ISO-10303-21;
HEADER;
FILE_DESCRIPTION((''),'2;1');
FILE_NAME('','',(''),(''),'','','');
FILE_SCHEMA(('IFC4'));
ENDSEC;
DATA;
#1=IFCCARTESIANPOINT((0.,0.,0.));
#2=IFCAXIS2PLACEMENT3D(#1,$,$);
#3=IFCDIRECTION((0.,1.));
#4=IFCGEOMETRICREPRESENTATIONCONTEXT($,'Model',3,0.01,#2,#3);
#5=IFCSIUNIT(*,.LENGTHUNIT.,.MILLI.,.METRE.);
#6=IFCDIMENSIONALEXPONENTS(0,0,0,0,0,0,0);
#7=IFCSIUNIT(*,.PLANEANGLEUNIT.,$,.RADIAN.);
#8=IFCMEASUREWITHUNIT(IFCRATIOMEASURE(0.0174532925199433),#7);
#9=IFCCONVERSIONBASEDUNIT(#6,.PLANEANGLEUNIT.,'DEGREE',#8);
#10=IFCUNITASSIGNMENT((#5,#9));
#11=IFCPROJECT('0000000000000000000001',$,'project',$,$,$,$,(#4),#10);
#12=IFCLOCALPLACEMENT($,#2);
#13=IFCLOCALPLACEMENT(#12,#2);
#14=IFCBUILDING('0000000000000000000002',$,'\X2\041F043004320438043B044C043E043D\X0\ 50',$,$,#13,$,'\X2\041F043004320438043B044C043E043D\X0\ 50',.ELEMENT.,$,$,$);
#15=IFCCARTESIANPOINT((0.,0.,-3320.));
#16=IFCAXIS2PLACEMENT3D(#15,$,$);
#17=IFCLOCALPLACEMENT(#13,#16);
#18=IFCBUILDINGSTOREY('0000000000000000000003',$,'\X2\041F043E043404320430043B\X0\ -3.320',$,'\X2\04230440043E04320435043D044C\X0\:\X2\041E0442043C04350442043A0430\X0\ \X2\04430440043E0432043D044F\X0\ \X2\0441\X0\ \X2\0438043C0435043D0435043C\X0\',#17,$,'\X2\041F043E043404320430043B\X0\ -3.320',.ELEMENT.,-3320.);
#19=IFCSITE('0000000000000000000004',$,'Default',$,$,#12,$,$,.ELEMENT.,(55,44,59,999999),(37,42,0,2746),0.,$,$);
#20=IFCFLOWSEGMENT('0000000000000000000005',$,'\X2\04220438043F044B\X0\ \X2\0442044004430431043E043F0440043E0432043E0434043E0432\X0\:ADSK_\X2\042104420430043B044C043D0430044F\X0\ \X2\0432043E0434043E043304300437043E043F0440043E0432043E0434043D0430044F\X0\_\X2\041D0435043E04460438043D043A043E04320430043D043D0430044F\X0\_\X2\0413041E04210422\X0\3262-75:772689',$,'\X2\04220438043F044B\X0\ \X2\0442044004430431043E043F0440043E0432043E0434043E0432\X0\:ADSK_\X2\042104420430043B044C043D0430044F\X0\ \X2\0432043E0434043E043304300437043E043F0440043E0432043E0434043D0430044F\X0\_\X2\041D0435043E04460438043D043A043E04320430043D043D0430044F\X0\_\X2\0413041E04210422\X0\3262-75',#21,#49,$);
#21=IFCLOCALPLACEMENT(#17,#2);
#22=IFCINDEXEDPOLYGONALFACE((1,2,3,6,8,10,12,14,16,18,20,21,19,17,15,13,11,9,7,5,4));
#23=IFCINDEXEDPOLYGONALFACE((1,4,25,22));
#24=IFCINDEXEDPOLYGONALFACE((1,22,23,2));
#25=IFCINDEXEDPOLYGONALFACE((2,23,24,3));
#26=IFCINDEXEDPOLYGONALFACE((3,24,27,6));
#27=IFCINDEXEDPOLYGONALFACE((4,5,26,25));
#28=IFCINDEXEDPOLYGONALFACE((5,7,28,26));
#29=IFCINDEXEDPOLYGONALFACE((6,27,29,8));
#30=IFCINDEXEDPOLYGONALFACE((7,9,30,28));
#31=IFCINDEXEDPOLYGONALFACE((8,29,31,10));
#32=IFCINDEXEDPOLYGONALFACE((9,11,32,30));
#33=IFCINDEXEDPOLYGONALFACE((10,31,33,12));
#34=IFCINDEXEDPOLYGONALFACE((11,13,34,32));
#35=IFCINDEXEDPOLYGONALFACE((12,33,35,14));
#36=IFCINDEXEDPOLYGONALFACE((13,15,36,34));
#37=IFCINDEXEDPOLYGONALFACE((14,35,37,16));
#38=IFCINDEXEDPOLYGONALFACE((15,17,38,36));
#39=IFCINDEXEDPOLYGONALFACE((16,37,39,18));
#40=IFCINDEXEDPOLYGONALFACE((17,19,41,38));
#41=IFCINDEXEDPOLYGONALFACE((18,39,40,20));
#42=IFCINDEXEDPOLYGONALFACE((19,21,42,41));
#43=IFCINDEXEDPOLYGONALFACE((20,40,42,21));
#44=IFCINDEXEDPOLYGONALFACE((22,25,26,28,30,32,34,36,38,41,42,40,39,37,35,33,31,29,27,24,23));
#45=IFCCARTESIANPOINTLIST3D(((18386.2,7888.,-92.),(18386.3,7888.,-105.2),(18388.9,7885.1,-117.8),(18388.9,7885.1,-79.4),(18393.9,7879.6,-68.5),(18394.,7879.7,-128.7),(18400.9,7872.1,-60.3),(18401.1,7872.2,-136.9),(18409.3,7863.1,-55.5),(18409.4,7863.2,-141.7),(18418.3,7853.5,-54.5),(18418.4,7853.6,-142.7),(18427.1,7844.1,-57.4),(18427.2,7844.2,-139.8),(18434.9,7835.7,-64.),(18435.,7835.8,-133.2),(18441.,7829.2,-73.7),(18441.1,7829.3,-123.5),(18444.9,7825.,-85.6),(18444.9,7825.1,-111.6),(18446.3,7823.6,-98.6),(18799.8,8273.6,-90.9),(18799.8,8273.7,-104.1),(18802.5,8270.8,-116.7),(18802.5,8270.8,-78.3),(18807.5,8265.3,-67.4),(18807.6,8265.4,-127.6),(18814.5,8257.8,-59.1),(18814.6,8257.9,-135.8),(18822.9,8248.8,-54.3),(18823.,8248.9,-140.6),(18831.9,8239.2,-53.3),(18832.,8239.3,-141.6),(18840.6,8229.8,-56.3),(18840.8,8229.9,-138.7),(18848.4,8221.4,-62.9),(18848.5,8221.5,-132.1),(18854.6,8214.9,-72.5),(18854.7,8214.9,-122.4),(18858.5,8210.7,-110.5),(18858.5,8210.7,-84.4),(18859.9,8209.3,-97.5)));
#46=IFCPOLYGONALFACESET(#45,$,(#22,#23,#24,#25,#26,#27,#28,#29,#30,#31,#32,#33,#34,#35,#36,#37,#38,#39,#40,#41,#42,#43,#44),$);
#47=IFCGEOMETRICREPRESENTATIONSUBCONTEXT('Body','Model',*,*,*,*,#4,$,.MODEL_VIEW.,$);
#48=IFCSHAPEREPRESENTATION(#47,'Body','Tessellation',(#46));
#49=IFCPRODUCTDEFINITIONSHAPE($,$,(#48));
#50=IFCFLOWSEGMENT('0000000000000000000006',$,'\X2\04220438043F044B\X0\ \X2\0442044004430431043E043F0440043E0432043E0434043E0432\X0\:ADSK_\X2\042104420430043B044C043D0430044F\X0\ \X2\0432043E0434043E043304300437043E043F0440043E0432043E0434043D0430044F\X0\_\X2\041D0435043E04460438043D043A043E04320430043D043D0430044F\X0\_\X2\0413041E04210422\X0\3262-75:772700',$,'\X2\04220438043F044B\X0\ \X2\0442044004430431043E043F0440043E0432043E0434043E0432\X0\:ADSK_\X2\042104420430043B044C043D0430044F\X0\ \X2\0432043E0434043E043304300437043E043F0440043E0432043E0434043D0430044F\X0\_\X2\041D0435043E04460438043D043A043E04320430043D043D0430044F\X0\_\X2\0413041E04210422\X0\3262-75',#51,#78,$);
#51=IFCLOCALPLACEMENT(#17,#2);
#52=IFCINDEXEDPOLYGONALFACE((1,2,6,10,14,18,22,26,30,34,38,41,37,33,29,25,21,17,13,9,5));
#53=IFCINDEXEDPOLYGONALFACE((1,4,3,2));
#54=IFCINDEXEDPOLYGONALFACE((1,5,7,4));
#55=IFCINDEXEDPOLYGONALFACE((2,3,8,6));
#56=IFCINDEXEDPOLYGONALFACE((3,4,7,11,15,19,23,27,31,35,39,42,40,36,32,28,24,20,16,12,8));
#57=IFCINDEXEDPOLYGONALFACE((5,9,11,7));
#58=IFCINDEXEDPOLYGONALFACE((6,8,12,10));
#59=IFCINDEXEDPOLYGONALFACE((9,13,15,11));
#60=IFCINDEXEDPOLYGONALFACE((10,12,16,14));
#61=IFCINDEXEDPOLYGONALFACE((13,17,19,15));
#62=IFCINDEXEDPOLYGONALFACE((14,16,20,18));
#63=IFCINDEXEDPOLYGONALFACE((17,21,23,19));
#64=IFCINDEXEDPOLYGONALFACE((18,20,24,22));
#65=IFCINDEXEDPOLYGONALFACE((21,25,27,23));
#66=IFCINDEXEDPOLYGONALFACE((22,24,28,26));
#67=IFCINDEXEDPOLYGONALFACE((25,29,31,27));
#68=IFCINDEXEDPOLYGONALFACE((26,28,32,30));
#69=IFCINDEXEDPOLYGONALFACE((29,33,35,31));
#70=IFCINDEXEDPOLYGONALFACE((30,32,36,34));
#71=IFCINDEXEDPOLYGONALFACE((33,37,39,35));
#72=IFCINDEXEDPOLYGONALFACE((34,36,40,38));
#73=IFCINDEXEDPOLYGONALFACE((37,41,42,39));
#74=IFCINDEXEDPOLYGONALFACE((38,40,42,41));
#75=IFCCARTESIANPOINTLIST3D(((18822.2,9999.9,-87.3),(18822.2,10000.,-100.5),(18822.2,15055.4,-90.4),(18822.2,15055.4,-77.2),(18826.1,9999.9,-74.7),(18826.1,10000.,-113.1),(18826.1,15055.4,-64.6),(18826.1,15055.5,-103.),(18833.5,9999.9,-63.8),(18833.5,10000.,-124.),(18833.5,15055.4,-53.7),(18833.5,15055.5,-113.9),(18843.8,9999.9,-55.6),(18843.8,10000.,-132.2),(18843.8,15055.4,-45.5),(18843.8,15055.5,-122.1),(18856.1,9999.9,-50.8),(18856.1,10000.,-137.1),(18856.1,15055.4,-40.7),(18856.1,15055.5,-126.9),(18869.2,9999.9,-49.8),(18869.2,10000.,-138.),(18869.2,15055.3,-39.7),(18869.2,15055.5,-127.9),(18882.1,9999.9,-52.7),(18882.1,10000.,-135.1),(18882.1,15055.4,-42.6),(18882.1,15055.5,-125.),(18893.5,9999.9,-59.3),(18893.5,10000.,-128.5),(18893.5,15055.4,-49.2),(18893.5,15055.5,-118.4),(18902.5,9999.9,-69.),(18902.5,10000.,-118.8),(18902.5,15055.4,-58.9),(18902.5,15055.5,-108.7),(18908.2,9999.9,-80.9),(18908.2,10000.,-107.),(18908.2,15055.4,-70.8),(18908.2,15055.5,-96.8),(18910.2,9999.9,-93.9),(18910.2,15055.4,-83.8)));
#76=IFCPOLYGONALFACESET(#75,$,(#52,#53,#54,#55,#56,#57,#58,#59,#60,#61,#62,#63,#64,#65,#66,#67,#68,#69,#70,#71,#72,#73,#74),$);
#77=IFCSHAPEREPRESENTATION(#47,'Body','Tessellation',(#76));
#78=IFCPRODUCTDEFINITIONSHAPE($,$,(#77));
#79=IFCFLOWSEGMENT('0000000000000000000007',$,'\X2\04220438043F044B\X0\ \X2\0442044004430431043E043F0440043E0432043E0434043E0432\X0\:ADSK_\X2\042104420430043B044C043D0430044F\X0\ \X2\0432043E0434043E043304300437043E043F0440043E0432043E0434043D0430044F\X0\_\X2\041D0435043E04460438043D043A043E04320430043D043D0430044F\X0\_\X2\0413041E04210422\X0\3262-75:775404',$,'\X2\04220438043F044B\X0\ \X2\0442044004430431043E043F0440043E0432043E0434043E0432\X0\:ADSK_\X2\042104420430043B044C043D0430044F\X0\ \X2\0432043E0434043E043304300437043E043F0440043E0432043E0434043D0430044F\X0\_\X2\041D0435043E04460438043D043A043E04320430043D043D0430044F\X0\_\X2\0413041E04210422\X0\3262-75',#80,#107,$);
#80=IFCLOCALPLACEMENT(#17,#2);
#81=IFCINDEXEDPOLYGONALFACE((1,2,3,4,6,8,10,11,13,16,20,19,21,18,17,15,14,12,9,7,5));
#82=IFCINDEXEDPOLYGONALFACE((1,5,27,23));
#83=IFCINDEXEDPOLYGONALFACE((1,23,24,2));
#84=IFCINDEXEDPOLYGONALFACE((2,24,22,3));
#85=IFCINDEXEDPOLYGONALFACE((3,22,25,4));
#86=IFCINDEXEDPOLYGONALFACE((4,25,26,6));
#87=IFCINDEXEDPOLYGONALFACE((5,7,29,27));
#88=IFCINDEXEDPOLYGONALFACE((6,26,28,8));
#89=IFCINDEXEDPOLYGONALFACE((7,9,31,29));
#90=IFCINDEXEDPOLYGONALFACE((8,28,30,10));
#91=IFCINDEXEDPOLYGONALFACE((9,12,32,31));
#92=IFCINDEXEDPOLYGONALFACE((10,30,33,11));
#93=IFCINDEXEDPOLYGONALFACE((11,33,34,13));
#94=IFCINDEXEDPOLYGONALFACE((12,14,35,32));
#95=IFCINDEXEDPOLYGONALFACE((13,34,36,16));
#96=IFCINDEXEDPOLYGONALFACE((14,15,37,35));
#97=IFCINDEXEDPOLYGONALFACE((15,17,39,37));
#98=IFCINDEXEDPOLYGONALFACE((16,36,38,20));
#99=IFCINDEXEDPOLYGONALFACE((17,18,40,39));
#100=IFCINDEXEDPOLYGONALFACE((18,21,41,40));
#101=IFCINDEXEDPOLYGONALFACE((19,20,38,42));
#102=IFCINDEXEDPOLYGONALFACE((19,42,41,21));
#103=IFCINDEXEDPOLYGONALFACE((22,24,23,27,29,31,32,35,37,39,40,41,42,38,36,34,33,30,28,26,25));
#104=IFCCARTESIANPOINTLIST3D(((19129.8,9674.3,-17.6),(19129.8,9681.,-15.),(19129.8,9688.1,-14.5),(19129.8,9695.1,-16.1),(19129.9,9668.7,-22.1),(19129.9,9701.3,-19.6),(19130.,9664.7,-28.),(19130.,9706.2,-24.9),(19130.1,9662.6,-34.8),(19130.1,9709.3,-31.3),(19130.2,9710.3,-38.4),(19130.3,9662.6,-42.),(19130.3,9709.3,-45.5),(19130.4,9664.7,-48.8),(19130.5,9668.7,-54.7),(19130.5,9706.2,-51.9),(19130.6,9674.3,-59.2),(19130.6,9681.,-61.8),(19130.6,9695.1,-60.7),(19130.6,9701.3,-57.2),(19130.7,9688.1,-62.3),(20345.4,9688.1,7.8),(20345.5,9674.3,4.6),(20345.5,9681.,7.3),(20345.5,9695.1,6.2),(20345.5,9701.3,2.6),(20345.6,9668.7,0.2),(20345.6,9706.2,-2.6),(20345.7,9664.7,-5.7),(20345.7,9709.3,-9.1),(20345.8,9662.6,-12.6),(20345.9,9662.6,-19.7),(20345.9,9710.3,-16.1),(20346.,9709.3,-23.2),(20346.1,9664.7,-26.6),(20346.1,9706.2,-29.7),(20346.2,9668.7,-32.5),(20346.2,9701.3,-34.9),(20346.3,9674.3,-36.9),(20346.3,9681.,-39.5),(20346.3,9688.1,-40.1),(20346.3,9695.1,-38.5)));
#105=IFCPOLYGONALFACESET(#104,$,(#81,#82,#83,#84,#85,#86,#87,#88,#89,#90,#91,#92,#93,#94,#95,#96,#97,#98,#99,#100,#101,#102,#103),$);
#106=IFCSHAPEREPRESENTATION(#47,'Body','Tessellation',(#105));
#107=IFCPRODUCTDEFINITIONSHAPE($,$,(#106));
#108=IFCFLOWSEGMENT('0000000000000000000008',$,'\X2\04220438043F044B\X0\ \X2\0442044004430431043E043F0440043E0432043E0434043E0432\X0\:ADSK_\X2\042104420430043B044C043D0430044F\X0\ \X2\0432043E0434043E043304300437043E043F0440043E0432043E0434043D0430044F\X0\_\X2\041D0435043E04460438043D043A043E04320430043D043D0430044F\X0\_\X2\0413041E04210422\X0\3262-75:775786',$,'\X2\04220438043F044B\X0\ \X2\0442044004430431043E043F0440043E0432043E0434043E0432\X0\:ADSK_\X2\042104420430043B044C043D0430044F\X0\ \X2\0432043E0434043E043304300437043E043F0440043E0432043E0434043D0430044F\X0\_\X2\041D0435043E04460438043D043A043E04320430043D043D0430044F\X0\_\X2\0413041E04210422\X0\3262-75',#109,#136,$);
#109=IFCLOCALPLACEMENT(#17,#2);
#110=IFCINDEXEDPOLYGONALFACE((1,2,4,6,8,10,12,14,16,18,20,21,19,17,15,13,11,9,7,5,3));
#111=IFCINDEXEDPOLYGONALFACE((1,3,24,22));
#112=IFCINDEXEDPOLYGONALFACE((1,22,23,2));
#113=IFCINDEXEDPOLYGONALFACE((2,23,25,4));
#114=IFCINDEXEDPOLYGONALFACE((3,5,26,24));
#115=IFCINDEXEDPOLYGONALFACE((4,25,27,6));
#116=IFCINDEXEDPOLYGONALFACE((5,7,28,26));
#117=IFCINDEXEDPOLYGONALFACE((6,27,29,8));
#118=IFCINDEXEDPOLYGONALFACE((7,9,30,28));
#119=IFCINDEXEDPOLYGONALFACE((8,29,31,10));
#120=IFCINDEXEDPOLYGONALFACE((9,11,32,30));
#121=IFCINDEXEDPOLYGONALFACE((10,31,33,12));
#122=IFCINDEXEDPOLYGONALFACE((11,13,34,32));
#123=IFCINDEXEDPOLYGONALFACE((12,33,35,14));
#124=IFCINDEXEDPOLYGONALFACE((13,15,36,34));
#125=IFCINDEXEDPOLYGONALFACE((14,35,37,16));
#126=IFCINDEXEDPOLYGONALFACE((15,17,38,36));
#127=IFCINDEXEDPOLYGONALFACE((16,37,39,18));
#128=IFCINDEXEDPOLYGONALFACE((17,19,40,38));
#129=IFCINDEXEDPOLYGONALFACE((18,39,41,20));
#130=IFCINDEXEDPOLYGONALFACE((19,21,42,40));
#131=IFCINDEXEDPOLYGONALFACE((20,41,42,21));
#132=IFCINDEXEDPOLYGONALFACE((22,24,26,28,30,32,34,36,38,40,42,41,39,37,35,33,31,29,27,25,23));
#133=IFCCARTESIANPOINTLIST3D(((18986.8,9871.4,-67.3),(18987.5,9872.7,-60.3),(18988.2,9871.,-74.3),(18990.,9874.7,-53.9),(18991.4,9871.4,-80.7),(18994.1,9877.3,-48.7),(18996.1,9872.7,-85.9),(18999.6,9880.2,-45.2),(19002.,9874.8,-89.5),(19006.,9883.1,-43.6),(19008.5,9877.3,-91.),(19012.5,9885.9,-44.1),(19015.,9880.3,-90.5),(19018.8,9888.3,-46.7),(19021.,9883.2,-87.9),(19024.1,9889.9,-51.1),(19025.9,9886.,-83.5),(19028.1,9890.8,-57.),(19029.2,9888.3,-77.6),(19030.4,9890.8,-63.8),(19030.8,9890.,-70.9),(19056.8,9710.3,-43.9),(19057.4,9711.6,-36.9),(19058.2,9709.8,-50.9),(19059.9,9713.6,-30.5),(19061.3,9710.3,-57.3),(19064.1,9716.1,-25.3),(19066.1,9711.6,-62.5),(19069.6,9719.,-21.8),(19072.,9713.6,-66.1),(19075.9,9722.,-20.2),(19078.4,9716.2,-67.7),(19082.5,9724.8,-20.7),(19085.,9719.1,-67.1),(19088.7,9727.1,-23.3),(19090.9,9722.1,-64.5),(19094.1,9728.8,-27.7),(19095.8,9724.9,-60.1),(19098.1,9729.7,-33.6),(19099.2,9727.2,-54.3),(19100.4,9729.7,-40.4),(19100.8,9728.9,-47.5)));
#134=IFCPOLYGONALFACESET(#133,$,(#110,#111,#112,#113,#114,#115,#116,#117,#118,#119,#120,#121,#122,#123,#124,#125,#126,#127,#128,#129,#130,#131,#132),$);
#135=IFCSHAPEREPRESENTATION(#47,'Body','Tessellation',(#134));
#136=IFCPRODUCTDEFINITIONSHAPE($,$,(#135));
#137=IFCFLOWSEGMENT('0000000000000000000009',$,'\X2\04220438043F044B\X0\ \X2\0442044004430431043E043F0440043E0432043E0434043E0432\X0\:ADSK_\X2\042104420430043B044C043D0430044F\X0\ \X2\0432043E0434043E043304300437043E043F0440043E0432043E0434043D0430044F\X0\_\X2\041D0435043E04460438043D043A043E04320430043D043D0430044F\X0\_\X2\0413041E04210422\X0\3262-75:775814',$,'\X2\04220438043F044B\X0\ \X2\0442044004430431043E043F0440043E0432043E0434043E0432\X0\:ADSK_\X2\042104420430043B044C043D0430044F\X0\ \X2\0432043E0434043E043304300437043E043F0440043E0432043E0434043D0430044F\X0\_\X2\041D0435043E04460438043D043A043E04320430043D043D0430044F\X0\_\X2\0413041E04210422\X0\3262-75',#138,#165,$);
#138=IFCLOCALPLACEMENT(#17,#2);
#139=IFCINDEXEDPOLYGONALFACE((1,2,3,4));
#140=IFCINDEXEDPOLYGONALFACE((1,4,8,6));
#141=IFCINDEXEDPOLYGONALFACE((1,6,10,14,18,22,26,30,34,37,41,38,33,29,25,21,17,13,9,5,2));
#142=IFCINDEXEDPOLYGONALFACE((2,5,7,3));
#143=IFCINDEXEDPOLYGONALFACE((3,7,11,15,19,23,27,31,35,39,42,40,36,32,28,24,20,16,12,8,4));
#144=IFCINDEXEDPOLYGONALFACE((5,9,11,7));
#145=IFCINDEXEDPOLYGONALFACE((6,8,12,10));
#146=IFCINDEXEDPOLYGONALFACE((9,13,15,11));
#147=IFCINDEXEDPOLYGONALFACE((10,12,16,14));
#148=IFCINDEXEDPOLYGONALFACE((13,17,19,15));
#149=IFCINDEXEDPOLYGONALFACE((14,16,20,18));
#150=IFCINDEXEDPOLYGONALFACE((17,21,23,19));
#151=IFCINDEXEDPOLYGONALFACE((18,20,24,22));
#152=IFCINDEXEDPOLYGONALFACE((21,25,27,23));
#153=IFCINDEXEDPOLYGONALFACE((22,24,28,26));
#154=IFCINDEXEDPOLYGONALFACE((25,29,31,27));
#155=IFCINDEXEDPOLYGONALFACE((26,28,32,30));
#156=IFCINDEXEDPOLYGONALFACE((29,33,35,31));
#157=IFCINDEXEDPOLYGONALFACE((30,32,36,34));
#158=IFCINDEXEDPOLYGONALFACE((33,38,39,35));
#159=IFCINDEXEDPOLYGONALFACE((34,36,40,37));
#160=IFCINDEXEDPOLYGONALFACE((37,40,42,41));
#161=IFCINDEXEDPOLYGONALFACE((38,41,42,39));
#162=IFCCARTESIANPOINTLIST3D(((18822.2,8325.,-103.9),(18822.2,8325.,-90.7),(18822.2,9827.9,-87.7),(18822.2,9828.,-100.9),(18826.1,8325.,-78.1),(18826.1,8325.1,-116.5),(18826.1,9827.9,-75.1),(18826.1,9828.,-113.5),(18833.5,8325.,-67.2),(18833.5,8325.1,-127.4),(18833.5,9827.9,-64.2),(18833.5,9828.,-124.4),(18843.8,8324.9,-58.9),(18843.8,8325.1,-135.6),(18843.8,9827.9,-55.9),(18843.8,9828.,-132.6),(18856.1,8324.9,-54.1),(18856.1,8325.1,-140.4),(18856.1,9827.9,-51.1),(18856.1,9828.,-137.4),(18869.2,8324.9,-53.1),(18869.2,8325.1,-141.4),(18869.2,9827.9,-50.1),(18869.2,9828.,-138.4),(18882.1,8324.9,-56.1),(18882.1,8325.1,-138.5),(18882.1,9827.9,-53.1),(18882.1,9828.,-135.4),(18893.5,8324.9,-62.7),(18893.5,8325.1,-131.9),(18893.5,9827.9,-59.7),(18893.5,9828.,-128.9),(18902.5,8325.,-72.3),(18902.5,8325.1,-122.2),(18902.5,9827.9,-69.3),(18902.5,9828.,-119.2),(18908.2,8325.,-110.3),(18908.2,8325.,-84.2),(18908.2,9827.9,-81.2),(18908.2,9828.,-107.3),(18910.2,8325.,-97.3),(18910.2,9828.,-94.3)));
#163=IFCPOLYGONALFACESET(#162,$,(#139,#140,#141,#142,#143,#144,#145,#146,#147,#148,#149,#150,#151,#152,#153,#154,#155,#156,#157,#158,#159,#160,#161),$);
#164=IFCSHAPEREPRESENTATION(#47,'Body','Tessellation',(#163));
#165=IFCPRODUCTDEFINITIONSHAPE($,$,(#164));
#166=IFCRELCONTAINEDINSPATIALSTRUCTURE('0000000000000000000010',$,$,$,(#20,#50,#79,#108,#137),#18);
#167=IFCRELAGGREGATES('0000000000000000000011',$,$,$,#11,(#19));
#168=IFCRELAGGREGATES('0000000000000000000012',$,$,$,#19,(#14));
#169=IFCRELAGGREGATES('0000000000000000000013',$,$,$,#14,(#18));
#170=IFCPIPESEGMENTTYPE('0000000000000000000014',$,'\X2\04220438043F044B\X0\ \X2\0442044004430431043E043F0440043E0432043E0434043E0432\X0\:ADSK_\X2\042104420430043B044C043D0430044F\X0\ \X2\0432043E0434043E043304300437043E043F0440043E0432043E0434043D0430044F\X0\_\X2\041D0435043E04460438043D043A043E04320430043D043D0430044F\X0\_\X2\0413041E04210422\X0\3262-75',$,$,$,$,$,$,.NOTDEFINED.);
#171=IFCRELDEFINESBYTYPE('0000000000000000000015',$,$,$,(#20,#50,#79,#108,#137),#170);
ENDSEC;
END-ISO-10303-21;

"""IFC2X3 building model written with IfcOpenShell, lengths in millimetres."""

from ifc_helpers import new_model, entity, si_unit, converted_unit, direction, frame, frame_2d, origin, origin_2d_with_axis, place, context, subcontext, project, spatial, circle, extrude, type_object, element, save


model = new_model("IFC2X3")

# Units and contexts
model_context = context("Model", 3, precision=0.01, world=origin(), true_north=direction((0.0, 1.0)))
body_context = subcontext(model_context, "Body", "Model", "MODEL_VIEW")
ifc_project = project(units=[si_unit("LENGTHUNIT", "METRE", prefix="MILLI"), converted_unit("PLANEANGLEUNIT", "DEGREE", entity("IfcRatioMeasure", 0.0174532925199433), si_unit("PLANEANGLEUNIT", "RADIAN"), dimensions=[0, 0, 0, 0, 0, 0, 0])], contexts=[model_context])

# Site, building, storey
site_placement = place(None, origin())
site = spatial("IfcSite", under=ifc_project, at=site_placement, Name="Default", CompositionType="ELEMENT", RefLatitude=(55, 44, 59, 999999), RefLongitude=(37, 42, 0, 2746), RefElevation=0.0)
building_placement = place(site_placement, origin())
building = spatial("IfcBuilding", under=site, at=building_placement, Name="Павильон 50", LongName="Павильон 50", CompositionType="ELEMENT")
storey_placement = place(building_placement, frame((0.0, 0.0, -3320.0)))
storey = spatial("IfcBuildingStorey", under=building, at=storey_placement, Name="Подвал -3.320", ObjectType="Уровень:Отметка уровня с именем", LongName="Подвал -3.320", CompositionType="ELEMENT", Elevation=-3320.0)

# Flow segments
pipe_segment_type = type_object("IfcPipeSegmentType", Name="Типы трубопроводов:ADSK_Стальная водогазопроводная_Неоцинкованная_ГОСТ3262-75", PredefinedType="NOTDEFINED")
flow_segment_1_placement = place(storey_placement, frame((18384.3, 7822.0, -144.4)))
element("IfcFlowSegment", 1, at=flow_segment_1_placement, inside=storey, type_object=pipe_segment_type, Name="Типы трубопроводов:ADSK_Стальная водогазопроводная_Неоцинкованная_ГОСТ3262-75:772689", ObjectType="Типы трубопроводов:ADSK_Стальная водогазопроводная_Неоцинкованная_ГОСТ3262-75", context=body_context, shape_type="SweptSolid", body=[
    extrude(circle(Radius=44.2, at=frame_2d((0.0, 0.0), x_axis=(1.0, 0.0))), frame((31.8, 34.0, 45.8), z_axis=(0.731352, 0.681997, 0.002), x_axis=(0.681998, -0.731354, 0.0)), (0.0, 0.0, 1.0), 565.5),
])
flow_segment_2_placement = place(storey_placement, frame((18820.1, 9999.9, -139.8)))
element("IfcFlowSegment", 2, at=flow_segment_2_placement, inside=storey, type_object=pipe_segment_type, Name="Типы трубопроводов:ADSK_Стальная водогазопроводная_Неоцинкованная_ГОСТ3262-75:772700", ObjectType="Типы трубопроводов:ADSK_Стальная водогазопроводная_Неоцинкованная_ГОСТ3262-75", context=body_context, shape_type="SweptSolid", body=[
    extrude(circle(Radius=44.2, at=origin_2d_with_axis()), frame((45.8, 0.1, 45.8), z_axis=(0.0, 0.999998, 0.002), x_axis=(1.0, 0.0, 0.0)), (0.0, 0.0, 1.0), 5055.5),
])
flow_segment_3_placement = place(storey_placement, frame((19128.2, 9660.7, -64.0)))
element("IfcFlowSegment", 3, at=flow_segment_3_placement, inside=storey, type_object=pipe_segment_type, Name="Типы трубопроводов:ADSK_Стальная водогазопроводная_Неоцинкованная_ГОСТ3262-75:775404", ObjectType="Типы трубопроводов:ADSK_Стальная водогазопроводная_Неоцинкованная_ГОСТ3262-75", context=body_context, shape_type="SweptSolid", body=[
    extrude(circle(Radius=24.0, at=frame_2d((0.0, 0.0), x_axis=(1.0, 0.0))), frame((2.0, 25.6, 25.6), z_axis=(0.999832, 0.0, 0.018305), x_axis=(0.0, 1.0, 0.0)), (0.0, 0.0, 1.0), 1215.9),
])
flow_segment_4_placement = place(storey_placement, frame((18985.2, 9708.3, -92.7)))
element("IfcFlowSegment", 4, at=flow_segment_4_placement, inside=storey, type_object=pipe_segment_type, Name="Типы трубопроводов:ADSK_Стальная водогазопроводная_Неоцинкованная_ГОСТ3262-75:775786", ObjectType="Типы трубопроводов:ADSK_Стальная водогазопроводная_Неоцинкованная_ГОСТ3262-75", context=body_context, shape_type="SweptSolid", body=[
    extrude(circle(Radius=24.0, at=origin_2d_with_axis()), frame((93.6, 11.6, 48.8), z_axis=(-0.394853, 0.909223, -0.131923), x_axis=(-0.91724, -0.398335, 0.0)), (0.0, 0.0, 1.0), 177.2),
])
flow_segment_5_placement = place(storey_placement, frame((18820.1, 8324.9, -143.1)))
element("IfcFlowSegment", 5, at=flow_segment_5_placement, inside=storey, type_object=pipe_segment_type, Name="Типы трубопроводов:ADSK_Стальная водогазопроводная_Неоцинкованная_ГОСТ3262-75:775814", ObjectType="Типы трубопроводов:ADSK_Стальная водогазопроводная_Неоцинкованная_ГОСТ3262-75", context=body_context, shape_type="SweptSolid", body=[
    extrude(circle(Radius=44.2, at=origin_2d_with_axis()), frame((45.8, 0.1, 45.8), z_axis=(0.0, 0.999998, 0.002), x_axis=(1.0, 0.0, 0.0)), (0.0, 0.0, 1.0), 1502.9),
])

save(model, "model.ifc")
